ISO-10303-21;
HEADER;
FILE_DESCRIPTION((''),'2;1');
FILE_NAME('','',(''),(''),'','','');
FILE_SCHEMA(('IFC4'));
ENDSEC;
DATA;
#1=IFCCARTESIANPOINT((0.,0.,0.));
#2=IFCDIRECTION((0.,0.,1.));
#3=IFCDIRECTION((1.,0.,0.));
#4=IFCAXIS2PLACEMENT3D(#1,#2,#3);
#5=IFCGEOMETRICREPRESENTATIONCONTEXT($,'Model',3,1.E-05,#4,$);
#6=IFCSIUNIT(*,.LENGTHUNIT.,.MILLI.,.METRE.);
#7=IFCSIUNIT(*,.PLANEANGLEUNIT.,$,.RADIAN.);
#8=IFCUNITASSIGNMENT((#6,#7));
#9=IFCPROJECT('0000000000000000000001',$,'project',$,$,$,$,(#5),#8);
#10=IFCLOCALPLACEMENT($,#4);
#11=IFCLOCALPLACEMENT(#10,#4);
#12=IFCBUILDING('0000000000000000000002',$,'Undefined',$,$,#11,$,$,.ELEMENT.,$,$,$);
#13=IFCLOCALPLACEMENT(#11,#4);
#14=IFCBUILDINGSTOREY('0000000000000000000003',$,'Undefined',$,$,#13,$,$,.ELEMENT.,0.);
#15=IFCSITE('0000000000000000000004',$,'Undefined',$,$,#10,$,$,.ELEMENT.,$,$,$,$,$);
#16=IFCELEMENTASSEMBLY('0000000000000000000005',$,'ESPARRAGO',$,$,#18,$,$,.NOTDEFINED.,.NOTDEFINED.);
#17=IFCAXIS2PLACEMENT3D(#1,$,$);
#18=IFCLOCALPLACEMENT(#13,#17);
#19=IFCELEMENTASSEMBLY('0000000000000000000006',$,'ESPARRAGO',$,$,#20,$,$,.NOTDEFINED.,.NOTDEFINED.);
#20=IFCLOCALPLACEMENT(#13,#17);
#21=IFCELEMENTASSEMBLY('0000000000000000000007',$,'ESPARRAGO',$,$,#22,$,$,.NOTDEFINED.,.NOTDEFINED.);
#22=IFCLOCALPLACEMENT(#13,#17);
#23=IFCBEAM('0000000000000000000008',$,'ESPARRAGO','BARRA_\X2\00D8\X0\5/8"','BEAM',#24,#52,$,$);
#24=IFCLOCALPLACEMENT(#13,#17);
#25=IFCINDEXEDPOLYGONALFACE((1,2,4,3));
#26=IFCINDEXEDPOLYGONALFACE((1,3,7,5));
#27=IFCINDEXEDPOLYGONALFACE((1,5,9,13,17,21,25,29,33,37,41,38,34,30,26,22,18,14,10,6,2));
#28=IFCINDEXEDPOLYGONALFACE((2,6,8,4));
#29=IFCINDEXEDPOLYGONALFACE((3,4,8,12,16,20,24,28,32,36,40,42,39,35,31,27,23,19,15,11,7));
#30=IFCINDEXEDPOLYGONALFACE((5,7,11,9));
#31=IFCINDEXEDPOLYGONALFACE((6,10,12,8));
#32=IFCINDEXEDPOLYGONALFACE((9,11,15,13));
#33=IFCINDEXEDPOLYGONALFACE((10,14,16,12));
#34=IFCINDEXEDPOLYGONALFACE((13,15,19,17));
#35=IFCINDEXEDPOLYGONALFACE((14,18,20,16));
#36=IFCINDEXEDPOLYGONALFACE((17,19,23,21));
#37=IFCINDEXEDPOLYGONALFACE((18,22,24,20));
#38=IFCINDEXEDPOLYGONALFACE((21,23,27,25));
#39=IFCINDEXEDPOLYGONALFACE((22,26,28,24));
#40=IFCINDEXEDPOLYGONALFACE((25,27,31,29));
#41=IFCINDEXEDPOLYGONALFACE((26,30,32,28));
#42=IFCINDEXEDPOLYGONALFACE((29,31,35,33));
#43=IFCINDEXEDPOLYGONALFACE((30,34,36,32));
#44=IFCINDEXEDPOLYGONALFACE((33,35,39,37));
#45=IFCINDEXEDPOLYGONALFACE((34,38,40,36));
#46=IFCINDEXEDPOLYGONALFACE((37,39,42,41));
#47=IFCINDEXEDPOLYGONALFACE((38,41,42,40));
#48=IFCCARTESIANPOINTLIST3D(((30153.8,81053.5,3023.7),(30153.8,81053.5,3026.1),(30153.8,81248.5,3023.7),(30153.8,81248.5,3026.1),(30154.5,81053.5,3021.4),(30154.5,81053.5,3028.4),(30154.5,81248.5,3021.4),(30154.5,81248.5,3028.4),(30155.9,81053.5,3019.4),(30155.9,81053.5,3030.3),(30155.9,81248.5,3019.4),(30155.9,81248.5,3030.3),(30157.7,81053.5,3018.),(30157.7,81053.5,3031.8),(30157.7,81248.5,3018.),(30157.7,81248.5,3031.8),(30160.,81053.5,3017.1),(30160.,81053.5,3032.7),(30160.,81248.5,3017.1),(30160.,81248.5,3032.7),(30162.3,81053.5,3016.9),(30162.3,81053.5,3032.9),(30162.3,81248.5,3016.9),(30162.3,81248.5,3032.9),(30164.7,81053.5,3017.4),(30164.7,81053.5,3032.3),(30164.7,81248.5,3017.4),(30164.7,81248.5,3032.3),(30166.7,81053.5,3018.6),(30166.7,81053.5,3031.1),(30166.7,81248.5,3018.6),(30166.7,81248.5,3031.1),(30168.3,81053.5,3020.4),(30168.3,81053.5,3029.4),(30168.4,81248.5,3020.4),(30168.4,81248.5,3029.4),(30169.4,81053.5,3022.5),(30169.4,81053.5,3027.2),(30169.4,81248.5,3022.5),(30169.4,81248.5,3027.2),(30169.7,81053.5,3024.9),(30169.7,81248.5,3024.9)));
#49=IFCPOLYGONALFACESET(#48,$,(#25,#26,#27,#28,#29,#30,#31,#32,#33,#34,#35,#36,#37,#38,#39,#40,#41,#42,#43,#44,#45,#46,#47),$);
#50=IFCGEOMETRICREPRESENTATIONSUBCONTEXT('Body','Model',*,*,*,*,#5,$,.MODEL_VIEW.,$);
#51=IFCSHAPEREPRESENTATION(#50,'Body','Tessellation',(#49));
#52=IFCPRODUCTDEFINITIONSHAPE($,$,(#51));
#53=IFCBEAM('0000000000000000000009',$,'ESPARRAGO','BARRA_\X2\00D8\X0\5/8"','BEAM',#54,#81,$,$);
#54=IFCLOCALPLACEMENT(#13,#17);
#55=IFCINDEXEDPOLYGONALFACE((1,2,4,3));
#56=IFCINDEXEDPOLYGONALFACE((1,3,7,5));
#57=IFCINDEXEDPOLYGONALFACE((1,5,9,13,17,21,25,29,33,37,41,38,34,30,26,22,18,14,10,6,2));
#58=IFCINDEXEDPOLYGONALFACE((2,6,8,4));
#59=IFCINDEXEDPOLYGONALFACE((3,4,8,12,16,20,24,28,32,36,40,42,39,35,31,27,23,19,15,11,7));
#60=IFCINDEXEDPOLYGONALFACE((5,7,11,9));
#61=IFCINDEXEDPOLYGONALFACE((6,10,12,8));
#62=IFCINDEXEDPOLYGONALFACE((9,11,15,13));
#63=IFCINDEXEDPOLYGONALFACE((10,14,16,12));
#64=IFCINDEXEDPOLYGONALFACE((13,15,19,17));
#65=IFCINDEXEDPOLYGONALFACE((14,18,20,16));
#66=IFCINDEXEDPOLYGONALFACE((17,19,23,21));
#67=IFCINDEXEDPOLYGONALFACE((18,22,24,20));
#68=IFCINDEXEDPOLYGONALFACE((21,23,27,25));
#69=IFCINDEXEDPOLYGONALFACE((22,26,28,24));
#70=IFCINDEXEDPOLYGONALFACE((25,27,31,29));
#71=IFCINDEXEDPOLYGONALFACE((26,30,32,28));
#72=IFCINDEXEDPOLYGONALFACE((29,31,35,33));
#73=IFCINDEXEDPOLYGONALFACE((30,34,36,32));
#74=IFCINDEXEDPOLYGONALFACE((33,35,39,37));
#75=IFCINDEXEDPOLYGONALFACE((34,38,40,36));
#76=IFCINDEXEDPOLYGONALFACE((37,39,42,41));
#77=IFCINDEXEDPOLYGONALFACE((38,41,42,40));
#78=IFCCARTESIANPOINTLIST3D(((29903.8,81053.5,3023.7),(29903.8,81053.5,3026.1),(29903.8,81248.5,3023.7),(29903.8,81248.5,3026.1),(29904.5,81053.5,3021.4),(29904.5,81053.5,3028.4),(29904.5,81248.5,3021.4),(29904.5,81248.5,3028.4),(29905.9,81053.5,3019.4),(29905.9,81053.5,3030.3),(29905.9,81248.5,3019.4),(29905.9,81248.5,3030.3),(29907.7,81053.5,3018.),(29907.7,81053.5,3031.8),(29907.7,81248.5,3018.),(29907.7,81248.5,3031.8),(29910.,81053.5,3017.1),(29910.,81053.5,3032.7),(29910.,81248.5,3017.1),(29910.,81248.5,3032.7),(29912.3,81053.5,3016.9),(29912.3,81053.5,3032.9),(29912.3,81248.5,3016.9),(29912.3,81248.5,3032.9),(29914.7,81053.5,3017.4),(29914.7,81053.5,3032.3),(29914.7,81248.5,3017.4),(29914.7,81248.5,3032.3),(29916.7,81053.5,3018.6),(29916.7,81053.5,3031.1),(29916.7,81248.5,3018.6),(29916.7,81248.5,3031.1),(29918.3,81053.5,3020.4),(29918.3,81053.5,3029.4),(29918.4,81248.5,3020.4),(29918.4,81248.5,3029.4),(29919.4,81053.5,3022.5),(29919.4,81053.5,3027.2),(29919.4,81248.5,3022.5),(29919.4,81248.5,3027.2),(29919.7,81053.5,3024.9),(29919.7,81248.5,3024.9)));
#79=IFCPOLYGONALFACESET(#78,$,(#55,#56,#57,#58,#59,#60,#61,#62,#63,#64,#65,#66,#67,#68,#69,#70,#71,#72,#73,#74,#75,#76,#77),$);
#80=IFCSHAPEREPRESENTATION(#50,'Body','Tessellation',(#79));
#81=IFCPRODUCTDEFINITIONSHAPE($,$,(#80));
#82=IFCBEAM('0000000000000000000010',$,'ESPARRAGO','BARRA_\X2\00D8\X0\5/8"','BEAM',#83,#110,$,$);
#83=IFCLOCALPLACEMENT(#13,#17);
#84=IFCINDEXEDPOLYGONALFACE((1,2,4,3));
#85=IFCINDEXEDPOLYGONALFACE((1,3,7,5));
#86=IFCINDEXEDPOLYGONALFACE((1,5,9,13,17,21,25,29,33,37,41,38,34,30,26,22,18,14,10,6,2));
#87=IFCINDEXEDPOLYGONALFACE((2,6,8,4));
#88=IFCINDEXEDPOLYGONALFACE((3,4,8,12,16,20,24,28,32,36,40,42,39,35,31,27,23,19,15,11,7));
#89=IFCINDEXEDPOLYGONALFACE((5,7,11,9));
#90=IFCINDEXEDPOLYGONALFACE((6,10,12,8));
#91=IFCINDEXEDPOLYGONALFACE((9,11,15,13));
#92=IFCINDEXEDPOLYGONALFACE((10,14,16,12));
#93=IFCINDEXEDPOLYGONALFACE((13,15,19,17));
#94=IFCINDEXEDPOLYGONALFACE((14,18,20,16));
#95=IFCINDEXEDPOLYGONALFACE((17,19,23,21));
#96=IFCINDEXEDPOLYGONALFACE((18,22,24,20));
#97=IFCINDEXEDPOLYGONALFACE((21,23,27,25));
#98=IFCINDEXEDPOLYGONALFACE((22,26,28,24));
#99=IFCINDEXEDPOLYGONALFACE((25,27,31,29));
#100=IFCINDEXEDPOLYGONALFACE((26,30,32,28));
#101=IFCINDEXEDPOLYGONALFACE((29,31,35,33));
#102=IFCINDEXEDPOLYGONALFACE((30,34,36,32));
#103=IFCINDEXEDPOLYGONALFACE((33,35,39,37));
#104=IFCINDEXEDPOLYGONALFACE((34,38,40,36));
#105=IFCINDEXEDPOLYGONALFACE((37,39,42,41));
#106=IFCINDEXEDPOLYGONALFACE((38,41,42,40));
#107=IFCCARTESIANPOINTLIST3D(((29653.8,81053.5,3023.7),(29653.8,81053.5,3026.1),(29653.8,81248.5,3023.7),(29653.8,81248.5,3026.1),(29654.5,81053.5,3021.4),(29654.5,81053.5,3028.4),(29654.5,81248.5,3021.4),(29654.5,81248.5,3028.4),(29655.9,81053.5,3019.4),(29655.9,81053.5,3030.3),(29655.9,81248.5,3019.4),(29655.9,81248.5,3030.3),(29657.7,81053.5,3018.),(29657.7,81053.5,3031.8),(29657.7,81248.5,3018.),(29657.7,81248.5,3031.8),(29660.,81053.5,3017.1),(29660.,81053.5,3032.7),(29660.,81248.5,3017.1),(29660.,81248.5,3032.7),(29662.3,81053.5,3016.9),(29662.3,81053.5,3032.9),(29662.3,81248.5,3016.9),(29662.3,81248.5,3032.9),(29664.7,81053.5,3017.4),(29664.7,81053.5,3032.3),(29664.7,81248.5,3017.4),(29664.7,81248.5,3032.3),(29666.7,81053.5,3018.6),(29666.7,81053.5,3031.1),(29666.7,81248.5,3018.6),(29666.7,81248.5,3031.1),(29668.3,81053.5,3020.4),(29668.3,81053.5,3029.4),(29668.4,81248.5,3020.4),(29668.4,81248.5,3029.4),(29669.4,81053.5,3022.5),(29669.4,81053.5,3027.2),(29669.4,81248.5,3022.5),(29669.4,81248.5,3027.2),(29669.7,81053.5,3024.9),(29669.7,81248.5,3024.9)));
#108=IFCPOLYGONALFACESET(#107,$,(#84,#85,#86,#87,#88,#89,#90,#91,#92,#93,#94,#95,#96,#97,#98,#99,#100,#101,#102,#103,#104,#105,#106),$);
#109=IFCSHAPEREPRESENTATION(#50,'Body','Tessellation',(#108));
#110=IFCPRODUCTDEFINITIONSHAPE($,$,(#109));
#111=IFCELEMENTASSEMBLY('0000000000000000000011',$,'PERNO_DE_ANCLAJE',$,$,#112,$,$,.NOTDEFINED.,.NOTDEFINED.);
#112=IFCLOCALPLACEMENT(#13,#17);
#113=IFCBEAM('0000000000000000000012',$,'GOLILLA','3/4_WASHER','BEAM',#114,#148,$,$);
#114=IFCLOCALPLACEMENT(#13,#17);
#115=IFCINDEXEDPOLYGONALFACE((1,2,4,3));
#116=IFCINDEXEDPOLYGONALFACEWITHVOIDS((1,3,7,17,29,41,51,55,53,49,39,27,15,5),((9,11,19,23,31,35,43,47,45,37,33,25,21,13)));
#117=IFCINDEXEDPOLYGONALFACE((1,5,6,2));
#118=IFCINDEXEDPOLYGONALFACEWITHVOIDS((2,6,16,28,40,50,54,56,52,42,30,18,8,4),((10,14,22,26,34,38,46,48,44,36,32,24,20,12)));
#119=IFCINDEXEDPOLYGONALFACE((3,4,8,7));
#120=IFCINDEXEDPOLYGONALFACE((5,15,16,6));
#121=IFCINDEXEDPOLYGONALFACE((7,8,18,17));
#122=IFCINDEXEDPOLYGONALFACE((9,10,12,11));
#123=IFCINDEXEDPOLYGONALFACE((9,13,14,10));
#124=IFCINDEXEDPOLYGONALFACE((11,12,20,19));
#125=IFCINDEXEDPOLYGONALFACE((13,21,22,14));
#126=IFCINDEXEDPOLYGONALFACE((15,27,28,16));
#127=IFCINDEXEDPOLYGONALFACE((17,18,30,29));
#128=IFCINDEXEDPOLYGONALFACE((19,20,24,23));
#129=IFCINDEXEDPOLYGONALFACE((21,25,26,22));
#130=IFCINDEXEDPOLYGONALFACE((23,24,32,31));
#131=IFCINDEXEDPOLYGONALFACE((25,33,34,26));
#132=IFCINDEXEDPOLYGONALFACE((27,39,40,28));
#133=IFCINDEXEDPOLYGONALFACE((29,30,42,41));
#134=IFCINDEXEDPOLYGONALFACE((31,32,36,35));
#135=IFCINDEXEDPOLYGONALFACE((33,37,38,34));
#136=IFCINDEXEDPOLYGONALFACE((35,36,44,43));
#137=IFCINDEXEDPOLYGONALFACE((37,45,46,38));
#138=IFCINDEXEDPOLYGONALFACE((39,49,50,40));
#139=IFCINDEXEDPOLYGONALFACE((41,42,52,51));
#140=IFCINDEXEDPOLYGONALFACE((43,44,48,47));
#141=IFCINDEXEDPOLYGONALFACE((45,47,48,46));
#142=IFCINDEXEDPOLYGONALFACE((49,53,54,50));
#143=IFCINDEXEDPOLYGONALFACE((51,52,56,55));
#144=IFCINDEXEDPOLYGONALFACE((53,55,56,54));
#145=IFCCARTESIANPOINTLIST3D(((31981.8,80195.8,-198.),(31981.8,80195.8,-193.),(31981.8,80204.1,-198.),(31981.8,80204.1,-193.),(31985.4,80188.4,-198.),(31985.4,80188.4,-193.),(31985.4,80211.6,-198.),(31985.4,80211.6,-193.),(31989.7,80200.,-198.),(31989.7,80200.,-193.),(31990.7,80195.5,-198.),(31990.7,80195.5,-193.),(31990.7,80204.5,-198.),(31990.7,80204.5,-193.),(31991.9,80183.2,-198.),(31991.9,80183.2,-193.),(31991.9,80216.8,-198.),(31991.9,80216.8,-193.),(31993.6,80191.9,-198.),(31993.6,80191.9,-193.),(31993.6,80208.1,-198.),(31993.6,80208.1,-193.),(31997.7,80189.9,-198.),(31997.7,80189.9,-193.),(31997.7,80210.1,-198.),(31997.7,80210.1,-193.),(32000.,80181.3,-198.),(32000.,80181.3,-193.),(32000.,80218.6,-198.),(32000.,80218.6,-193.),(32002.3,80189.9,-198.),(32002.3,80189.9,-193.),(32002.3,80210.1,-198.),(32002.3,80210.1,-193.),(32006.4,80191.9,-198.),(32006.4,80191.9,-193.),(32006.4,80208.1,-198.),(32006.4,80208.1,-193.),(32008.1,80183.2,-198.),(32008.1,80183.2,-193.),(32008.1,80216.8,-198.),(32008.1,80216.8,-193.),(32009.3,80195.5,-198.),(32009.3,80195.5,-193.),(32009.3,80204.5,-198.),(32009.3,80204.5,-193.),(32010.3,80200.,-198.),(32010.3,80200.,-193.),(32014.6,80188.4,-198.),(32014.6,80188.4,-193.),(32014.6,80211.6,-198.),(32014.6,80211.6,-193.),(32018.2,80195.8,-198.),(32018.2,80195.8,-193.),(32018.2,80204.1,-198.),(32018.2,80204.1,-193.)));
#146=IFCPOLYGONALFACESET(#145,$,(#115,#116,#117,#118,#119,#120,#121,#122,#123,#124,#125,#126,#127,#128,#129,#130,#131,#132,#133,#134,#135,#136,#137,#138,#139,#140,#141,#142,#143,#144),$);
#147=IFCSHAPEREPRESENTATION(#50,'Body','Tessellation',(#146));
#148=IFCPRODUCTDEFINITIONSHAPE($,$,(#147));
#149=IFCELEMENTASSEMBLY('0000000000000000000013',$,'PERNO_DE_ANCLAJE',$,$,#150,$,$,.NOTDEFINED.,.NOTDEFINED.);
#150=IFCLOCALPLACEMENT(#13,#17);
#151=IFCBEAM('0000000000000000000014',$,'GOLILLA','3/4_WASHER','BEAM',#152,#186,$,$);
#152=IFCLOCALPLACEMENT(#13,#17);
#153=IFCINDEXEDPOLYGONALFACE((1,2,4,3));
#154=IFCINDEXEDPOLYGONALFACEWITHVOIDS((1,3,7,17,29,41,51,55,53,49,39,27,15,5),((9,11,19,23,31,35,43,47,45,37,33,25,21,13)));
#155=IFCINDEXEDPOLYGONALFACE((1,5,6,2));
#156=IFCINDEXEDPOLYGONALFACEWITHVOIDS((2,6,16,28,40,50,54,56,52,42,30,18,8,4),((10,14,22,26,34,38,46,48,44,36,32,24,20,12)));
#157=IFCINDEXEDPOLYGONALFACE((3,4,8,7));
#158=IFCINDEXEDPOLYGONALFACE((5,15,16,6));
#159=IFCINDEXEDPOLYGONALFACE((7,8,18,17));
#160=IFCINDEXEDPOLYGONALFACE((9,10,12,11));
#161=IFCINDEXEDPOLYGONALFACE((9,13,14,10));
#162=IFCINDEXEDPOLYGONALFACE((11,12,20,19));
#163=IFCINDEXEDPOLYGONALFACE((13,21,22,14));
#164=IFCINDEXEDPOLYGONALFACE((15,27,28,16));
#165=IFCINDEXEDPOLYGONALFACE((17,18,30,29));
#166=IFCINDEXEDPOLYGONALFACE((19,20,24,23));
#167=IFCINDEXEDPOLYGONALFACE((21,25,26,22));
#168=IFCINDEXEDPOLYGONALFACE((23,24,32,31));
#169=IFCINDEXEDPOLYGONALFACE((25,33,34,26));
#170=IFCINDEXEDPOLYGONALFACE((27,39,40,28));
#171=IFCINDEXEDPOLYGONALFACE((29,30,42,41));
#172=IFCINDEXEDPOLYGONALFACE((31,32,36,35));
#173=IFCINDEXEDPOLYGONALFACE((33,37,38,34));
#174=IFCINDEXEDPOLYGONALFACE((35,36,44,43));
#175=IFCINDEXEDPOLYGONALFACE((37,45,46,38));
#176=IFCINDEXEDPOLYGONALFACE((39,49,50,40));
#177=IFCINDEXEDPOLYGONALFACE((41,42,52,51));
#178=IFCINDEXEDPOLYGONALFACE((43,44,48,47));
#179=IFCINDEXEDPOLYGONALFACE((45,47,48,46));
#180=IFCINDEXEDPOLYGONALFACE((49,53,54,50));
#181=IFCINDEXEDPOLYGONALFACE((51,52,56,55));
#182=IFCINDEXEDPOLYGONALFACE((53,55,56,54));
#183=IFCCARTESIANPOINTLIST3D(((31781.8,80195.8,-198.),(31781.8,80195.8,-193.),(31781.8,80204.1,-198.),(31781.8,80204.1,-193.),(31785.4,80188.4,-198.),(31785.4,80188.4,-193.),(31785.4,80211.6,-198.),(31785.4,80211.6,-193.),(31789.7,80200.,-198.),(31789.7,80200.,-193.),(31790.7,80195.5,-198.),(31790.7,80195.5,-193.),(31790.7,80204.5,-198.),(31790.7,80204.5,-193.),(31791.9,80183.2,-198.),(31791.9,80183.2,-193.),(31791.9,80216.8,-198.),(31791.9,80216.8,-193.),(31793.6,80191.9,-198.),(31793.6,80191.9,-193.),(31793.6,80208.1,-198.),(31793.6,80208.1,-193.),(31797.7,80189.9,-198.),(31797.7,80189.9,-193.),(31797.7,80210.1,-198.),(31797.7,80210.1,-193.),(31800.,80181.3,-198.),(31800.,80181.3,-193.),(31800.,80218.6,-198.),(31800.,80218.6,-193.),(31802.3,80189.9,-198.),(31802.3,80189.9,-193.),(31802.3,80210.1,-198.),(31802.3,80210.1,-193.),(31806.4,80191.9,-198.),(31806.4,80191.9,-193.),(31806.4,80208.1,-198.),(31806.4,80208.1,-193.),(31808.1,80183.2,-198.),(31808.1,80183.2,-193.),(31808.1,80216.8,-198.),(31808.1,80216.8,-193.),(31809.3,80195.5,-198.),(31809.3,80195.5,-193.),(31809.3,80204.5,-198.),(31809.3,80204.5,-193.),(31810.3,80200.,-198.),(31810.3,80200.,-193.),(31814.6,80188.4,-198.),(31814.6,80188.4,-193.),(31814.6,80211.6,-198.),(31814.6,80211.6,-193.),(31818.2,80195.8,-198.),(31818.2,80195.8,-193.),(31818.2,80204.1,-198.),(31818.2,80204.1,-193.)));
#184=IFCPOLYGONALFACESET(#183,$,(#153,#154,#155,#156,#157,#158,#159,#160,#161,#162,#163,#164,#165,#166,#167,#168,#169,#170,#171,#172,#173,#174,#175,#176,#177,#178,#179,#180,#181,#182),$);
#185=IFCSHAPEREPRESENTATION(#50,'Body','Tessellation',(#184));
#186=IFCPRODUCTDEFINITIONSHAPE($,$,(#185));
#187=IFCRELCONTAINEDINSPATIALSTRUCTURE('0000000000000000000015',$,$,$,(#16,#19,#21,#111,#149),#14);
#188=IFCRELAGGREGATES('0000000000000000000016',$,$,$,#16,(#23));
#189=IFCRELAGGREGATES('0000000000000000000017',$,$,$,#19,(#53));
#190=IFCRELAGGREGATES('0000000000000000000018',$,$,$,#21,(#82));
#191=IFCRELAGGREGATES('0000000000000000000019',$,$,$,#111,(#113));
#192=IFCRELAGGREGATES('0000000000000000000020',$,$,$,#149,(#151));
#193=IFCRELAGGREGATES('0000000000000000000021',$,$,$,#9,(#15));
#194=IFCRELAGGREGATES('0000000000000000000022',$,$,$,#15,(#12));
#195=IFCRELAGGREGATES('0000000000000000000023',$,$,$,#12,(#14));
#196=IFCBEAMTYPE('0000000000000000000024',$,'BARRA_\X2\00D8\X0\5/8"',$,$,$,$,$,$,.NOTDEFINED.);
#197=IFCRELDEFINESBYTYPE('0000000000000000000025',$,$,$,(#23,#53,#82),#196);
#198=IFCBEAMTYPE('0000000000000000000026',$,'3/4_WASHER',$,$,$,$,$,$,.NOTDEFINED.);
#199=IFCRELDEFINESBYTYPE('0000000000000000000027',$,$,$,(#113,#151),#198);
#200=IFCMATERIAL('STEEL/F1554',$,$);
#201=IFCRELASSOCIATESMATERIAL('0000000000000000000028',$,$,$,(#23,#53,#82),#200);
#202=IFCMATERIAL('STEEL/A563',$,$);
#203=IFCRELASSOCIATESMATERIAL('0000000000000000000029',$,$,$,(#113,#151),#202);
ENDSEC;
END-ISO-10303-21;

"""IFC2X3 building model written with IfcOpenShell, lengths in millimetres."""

from ifc_helpers import new_model, si_unit, frame, origin_with_axes, origin_2d_with_axis, place, context, subcontext, project, spatial, polyline, circle, outline, extrude, material, type_object, element, aggregate, save


model = new_model("IFC2X3")

# Units and contexts
model_context = context("Model", 3, precision=1e-05, world=origin_with_axes())
body_context = subcontext(model_context, "Body", "Model", "MODEL_VIEW")
ifc_project = project(units=[si_unit("LENGTHUNIT", "METRE", prefix="MILLI"), si_unit("PLANEANGLEUNIT", "RADIAN")], contexts=[model_context])

# Site, building, storey
site_placement = place(None, origin_with_axes())
site = spatial("IfcSite", under=ifc_project, at=site_placement, Name="Undefined", CompositionType="ELEMENT")
building_placement = place(site_placement, origin_with_axes())
building = spatial("IfcBuilding", under=site, at=building_placement, Name="Undefined", CompositionType="ELEMENT")
storey_placement = place(building_placement, origin_with_axes())
storey = spatial("IfcBuildingStorey", under=building, at=storey_placement, Name="Undefined", CompositionType="ELEMENT", Elevation=0.0)

# Element assemblies
assembly_1_placement = place(storey_placement, origin_with_axes())
assembly_1 = element("IfcElementAssembly", 1, at=assembly_1_placement, inside=storey, Name="ESPARRAGO", AssemblyPlace="NOTDEFINED", PredefinedType="NOTDEFINED")
assembly_2_placement = place(storey_placement, origin_with_axes())
assembly_2 = element("IfcElementAssembly", 2, at=assembly_2_placement, inside=storey, Name="ESPARRAGO", AssemblyPlace="NOTDEFINED", PredefinedType="NOTDEFINED")
assembly_3_placement = place(storey_placement, origin_with_axes())
assembly_3 = element("IfcElementAssembly", 3, at=assembly_3_placement, inside=storey, Name="ESPARRAGO", AssemblyPlace="NOTDEFINED", PredefinedType="NOTDEFINED")
ifc_material_1 = material(Name="STEEL/F1554")
beam_type_1 = type_object("IfcBeamType", Name="BARRA_Ø5/8\"", PredefinedType="NOTDEFINED")

# Beams
beam_1_placement = place(assembly_1_placement, frame((30161.7, 81053.5, 3024.9), z_axis=(0.0, 0.0, 1.0), x_axis=(0.000021, 1.0, 0.0)))
beam_1 = element("IfcBeam", 4, at=beam_1_placement, type_object=beam_type_1, material=ifc_material_1, Name="ESPARRAGO", Description="BARRA_Ø5/8\"", ObjectType="BEAM", context=body_context, shape_type="SweptSolid", body=[
    extrude(circle(Radius=8.0, at=origin_2d_with_axis()), frame((195.0, 0.0, 0.0), z_axis=(-1.0, 0.0, 0.0), x_axis=(0.0, -1.0, 0.0)), (0.0, 0.0, 1.0), 195.0),
])
aggregate(assembly_1, [beam_1])
beam_2_placement = place(assembly_2_placement, frame((29911.7, 81053.5, 3024.9), z_axis=(0.0, 0.0, 1.0), x_axis=(0.000021, 1.0, 0.0)))
beam_2 = element("IfcBeam", 5, at=beam_2_placement, type_object=beam_type_1, material=ifc_material_1, Name="ESPARRAGO", Description="BARRA_Ø5/8\"", ObjectType="BEAM", context=body_context, shape_type="SweptSolid", body=[
    extrude(circle(Radius=8.0, at=origin_2d_with_axis()), frame((195.0, 0.0, 0.0), z_axis=(-1.0, 0.0, 0.0), x_axis=(0.0, -1.0, 0.0)), (0.0, 0.0, 1.0), 195.0),
])
aggregate(assembly_2, [beam_2])
beam_3_placement = place(assembly_3_placement, frame((29661.7, 81053.5, 3024.9), z_axis=(0.0, 0.0, 1.0), x_axis=(0.000021, 1.0, 0.0)))
beam_3 = element("IfcBeam", 6, at=beam_3_placement, type_object=beam_type_1, material=ifc_material_1, Name="ESPARRAGO", Description="BARRA_Ø5/8\"", ObjectType="BEAM", context=body_context, shape_type="SweptSolid", body=[
    extrude(circle(Radius=8.0, at=origin_2d_with_axis()), frame((195.0, 0.0, 0.0), z_axis=(-1.0, 0.0, 0.0), x_axis=(0.0, -1.0, 0.0)), (0.0, 0.0, 1.0), 195.0),
])
aggregate(assembly_3, [beam_3])

# Element assemblies, beams
assembly_4_placement = place(storey_placement, origin_with_axes())
assembly_4 = element("IfcElementAssembly", 7, at=assembly_4_placement, inside=storey, Name="PERNO_DE_ANCLAJE", AssemblyPlace="NOTDEFINED", PredefinedType="NOTDEFINED")
ifc_material_2 = material(Name="STEEL/A563")
beam_type_2 = type_object("IfcBeamType", Name="3/4_WASHER", PredefinedType="NOTDEFINED")
beam_4_placement = place(assembly_4_placement, frame((32000.0, 80200.0, -193.0), z_axis=(1.0, 0.0, 0.0), x_axis=(0.0, 0.00008, -1.0)))
beam_4 = element("IfcBeam", 8, at=beam_4_placement, type_object=beam_type_2, material=ifc_material_2, Name="GOLILLA", Description="3/4_WASHER", ObjectType="BEAM", context=body_context, shape_type="SweptSolid", body=[
    extrude(outline(polyline([(-16.8, 8.1), (-11.6, 14.6), (-4.2, 18.2), (4.2, 18.2), (11.6, 14.6), (16.8, 8.1), (18.6, 0.0), (16.8, -8.1), (11.6, -14.6), (4.2, -18.2), (-4.2, -18.2), (-11.6, -14.6), (-16.8, -8.1), (-18.6, 0.0), (-16.8, 8.1)]), holes=[polyline([(8.1, 6.4), (4.5, 9.3), (0.0, 10.3), (-4.5, 9.3), (-8.1, 6.4), (-10.1, 2.3), (-10.1, -2.3), (-8.1, -6.4), (-4.5, -9.3), (0.0, -10.3), (4.5, -9.3), (8.1, -6.4), (10.1, -2.3), (10.1, 2.3), (8.1, 6.4)])]), frame((5.0, 0.0, 0.0), z_axis=(-1.0, 0.0, 0.0), x_axis=(0.0, -1.0, 0.0)), (0.0, 0.0, 1.0), 5.0),
])
assembly_5_placement = place(storey_placement, origin_with_axes())
assembly_5 = element("IfcElementAssembly", 9, at=assembly_5_placement, inside=storey, Name="PERNO_DE_ANCLAJE", AssemblyPlace="NOTDEFINED", PredefinedType="NOTDEFINED")
beam_5_placement = place(assembly_5_placement, frame((31800.0, 80200.0, -193.0), z_axis=(1.0, 0.0, 0.0), x_axis=(0.0, 0.00008, -1.0)))
beam_5 = element("IfcBeam", 10, at=beam_5_placement, type_object=beam_type_2, material=ifc_material_2, Name="GOLILLA", Description="3/4_WASHER", ObjectType="BEAM", context=body_context, shape_type="SweptSolid", body=[
    extrude(outline(polyline([(-16.8, 8.1), (-11.6, 14.6), (-4.2, 18.2), (4.2, 18.2), (11.6, 14.6), (16.8, 8.1), (18.6, 0.0), (16.8, -8.1), (11.6, -14.6), (4.2, -18.2), (-4.2, -18.2), (-11.6, -14.6), (-16.8, -8.1), (-18.6, 0.0), (-16.8, 8.1)]), holes=[polyline([(8.1, 6.4), (4.5, 9.3), (0.0, 10.3), (-4.5, 9.3), (-8.1, 6.4), (-10.1, 2.3), (-10.1, -2.3), (-8.1, -6.4), (-4.5, -9.3), (0.0, -10.3), (4.5, -9.3), (8.1, -6.4), (10.1, -2.3), (10.1, 2.3), (8.1, 6.4)])]), frame((5.0, 0.0, 0.0), z_axis=(-1.0, 0.0, 0.0), x_axis=(0.0, -1.0, 0.0)), (0.0, 0.0, 1.0), 5.0),
])

aggregate(assembly_4, [beam_4])
aggregate(assembly_5, [beam_5])

save(model, "model.ifc")
